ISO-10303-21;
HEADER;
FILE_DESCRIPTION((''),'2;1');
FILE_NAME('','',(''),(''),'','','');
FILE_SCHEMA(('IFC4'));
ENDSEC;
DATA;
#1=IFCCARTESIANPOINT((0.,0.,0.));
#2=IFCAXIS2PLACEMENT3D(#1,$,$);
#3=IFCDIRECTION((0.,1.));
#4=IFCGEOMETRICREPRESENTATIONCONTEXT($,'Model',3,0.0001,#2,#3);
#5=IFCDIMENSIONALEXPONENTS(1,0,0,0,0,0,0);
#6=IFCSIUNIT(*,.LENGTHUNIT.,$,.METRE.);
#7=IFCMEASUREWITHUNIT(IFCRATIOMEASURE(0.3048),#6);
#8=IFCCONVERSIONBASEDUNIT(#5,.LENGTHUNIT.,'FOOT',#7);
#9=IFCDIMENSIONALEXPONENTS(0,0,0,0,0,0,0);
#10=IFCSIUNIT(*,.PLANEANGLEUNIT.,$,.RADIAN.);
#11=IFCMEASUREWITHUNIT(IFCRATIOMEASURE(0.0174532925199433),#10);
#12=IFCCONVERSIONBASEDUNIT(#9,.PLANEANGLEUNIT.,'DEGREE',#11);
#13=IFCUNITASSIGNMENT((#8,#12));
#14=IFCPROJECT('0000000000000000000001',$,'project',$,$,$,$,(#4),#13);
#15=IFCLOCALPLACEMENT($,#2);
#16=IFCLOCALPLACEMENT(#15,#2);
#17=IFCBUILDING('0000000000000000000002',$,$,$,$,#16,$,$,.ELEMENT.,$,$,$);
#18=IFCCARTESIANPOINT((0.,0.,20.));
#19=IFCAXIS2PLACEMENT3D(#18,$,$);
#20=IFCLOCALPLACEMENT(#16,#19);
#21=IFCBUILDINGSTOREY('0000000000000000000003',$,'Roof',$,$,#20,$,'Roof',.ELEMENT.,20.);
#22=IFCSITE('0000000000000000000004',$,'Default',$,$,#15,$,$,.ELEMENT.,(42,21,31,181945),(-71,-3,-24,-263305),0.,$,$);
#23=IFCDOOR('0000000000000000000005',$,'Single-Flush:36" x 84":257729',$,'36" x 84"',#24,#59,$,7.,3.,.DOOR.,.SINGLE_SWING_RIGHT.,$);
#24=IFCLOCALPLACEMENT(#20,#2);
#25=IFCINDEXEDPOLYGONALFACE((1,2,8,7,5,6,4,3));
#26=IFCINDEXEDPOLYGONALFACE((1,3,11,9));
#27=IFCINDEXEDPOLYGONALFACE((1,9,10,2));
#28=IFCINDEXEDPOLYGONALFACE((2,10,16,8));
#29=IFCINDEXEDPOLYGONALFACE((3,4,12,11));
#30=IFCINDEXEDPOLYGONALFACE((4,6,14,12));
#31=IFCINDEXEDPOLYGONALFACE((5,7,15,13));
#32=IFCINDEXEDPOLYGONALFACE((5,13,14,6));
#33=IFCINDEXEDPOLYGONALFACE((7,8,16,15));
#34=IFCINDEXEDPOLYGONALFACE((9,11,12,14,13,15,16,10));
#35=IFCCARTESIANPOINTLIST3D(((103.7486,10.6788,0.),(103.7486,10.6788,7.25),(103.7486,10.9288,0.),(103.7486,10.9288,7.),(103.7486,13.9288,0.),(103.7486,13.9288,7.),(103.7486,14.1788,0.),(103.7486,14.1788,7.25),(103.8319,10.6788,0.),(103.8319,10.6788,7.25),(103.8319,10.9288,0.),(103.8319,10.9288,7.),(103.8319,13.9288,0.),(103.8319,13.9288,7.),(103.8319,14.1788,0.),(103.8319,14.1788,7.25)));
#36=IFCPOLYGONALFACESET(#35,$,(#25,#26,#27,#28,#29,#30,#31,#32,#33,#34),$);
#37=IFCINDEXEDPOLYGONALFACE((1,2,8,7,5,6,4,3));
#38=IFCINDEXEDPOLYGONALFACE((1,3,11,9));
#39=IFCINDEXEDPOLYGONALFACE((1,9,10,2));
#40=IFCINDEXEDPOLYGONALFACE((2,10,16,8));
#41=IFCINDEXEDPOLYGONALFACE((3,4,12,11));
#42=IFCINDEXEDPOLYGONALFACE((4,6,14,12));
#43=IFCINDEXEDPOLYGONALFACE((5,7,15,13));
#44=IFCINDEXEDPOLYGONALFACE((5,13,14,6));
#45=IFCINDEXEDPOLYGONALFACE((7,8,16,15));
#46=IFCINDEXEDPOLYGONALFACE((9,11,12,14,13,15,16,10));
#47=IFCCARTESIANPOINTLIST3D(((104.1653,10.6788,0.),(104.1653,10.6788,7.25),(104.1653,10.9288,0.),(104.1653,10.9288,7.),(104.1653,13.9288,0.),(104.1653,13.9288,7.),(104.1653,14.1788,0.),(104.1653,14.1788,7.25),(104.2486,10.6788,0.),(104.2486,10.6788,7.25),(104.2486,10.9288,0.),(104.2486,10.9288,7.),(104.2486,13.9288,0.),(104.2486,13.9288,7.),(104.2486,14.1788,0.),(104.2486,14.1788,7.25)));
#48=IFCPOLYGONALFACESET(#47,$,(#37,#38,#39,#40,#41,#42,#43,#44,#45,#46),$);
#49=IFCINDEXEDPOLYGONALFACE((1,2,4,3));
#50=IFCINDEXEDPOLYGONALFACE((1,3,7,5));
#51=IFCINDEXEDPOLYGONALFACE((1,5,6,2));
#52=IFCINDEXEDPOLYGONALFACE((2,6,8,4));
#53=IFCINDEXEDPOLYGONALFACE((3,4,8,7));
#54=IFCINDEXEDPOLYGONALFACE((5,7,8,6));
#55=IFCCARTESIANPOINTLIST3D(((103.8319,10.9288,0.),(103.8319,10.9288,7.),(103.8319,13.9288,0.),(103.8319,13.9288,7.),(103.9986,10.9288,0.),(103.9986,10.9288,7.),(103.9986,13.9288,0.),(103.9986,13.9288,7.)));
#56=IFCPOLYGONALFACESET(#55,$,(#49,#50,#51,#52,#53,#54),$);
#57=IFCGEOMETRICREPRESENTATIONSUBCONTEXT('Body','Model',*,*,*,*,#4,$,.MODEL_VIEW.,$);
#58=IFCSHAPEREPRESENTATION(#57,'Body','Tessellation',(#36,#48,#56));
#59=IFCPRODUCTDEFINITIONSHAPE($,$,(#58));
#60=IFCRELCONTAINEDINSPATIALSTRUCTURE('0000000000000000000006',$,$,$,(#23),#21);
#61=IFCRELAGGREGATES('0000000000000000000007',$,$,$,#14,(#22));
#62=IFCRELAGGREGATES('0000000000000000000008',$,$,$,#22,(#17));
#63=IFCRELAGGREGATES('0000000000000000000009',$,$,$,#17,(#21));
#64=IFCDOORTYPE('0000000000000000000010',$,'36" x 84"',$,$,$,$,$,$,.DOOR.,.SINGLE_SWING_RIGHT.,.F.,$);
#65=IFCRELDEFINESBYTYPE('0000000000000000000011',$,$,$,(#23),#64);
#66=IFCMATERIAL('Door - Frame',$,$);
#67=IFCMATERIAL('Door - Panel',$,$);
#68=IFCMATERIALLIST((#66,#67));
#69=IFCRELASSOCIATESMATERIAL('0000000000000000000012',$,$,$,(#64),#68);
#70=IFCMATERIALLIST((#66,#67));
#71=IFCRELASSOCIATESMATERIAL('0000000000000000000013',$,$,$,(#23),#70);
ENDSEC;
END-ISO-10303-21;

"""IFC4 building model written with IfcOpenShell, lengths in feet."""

from ifc_helpers import new_model, entity, si_unit, converted_unit, direction, frame, frame_2d, origin, place, context, subcontext, project, spatial, polyline, rectangle, outline, extrude, source, transform, mapped, material, material_list, type_object, type_shapes, element, save


model = new_model("IFC4")

# Units and contexts
model_context = context("Model", 3, precision=0.0001, world=origin(), true_north=direction((0.0, 1.0)))
body_context = subcontext(model_context, "Body", "Model", "MODEL_VIEW")
ifc_project = project(units=[converted_unit("LENGTHUNIT", "FOOT", entity("IfcRatioMeasure", 0.3048), si_unit("LENGTHUNIT", "METRE"), dimensions=[1, 0, 0, 0, 0, 0, 0]), converted_unit("PLANEANGLEUNIT", "DEGREE", entity("IfcRatioMeasure", 0.0174532925199433), si_unit("PLANEANGLEUNIT", "RADIAN"), dimensions=[0, 0, 0, 0, 0, 0, 0])], contexts=[model_context])

# Site, building, storey
site_placement = place(None, origin())
site = spatial("IfcSite", under=ifc_project, at=site_placement, Name="Default", CompositionType="ELEMENT", RefLatitude=(42, 21, 31, 181945), RefLongitude=(-71, -3, -24, -263305), RefElevation=0.0)
building_placement = place(site_placement, origin())
building = spatial("IfcBuilding", under=site, at=building_placement, CompositionType="ELEMENT")
storey_placement = place(building_placement, frame((0.0, 0.0, 20.0)))
storey = spatial("IfcBuildingStorey", under=building, at=storey_placement, Name="Roof", LongName="Roof", CompositionType="ELEMENT", Elevation=20.0)

# Shared definitions
placement_1 = place(storey_placement, frame((103.9986, -6.9045, 0.0), z_axis=(0.0, 0.0, 1.0), x_axis=(0.0, 1.0, 0.0)))

# Door
ifc_material_1 = material(Name="Door - Frame")
ifc_material_2 = material(Name="Door - Panel")
ifc_material_list_1 = material_list([ifc_material_1, ifc_material_2])
ifc_material_list_2 = material_list([ifc_material_1, ifc_material_2])
door_type = type_object("IfcDoorType", Name="36\" x 84\"", OperationType="SINGLE_SWING_RIGHT", ParameterTakesPrecedence=False, PredefinedType="DOOR", material=ifc_material_list_2)
shared_shape = source(origin(), body_context, "Body", "SweptSolid", [
    extrude(outline(polyline([(-1.75, -3.6875), (1.75, -3.6875), (1.75, 3.5625), (1.5, 3.5625), (1.5, -3.4375), (-1.5, -3.4375), (-1.5, 3.5625), (-1.75, 3.5625), (-1.75, -3.6875)])), frame((1.5, 0.3333, 3.5625), z_axis=(0.0, 1.0, 0.0), x_axis=(1.0, 0.0, 0.0)), (0.0, 0.0, 1.0), 0.0833),
    extrude(outline(polyline([(-3.6875, -1.75), (3.5625, -1.75), (3.5625, -1.5), (-3.4375, -1.5), (-3.4375, 1.5), (3.5625, 1.5), (3.5625, 1.75), (-3.6875, 1.75), (-3.6875, -1.75)])), frame((1.5, -0.0833, 3.5625), z_axis=(0.0, 1.0, 0.0), x_axis=(0.0, 0.0, -1.0)), (0.0, 0.0, 1.0), 0.0833),
    extrude(rectangle(XDim=0.1667, YDim=3.0, at=frame_2d((0.0, 0.0), x_axis=(1.0, 0.0))), frame((1.5, 0.25, 0.0), z_axis=(0.0, 0.0, 1.0), x_axis=(0.0, 1.0, 0.0)), (0.0, 0.0, 1.0), 7.0),
])
type_shapes(door_type, [shared_shape])
placement_2 = place(placement_1, frame((17.8333, -0.1667, 0.0)))
door_placement = place(placement_2, origin())
element("IfcDoor", 1, at=door_placement, inside=storey, type_object=door_type, material=ifc_material_list_1, Name="Single-Flush:36\" x 84\":257729", ObjectType="36\" x 84\"", OperationType="SINGLE_SWING_RIGHT", OverallHeight=7.0, OverallWidth=3.0, PredefinedType="DOOR", context=body_context, shape_type="MappedRepresentation", body=[
    mapped(shared_shape, transform((0.0, 0.0, 0.0), scale=1.0)),
])

save(model, "model.ifc")
